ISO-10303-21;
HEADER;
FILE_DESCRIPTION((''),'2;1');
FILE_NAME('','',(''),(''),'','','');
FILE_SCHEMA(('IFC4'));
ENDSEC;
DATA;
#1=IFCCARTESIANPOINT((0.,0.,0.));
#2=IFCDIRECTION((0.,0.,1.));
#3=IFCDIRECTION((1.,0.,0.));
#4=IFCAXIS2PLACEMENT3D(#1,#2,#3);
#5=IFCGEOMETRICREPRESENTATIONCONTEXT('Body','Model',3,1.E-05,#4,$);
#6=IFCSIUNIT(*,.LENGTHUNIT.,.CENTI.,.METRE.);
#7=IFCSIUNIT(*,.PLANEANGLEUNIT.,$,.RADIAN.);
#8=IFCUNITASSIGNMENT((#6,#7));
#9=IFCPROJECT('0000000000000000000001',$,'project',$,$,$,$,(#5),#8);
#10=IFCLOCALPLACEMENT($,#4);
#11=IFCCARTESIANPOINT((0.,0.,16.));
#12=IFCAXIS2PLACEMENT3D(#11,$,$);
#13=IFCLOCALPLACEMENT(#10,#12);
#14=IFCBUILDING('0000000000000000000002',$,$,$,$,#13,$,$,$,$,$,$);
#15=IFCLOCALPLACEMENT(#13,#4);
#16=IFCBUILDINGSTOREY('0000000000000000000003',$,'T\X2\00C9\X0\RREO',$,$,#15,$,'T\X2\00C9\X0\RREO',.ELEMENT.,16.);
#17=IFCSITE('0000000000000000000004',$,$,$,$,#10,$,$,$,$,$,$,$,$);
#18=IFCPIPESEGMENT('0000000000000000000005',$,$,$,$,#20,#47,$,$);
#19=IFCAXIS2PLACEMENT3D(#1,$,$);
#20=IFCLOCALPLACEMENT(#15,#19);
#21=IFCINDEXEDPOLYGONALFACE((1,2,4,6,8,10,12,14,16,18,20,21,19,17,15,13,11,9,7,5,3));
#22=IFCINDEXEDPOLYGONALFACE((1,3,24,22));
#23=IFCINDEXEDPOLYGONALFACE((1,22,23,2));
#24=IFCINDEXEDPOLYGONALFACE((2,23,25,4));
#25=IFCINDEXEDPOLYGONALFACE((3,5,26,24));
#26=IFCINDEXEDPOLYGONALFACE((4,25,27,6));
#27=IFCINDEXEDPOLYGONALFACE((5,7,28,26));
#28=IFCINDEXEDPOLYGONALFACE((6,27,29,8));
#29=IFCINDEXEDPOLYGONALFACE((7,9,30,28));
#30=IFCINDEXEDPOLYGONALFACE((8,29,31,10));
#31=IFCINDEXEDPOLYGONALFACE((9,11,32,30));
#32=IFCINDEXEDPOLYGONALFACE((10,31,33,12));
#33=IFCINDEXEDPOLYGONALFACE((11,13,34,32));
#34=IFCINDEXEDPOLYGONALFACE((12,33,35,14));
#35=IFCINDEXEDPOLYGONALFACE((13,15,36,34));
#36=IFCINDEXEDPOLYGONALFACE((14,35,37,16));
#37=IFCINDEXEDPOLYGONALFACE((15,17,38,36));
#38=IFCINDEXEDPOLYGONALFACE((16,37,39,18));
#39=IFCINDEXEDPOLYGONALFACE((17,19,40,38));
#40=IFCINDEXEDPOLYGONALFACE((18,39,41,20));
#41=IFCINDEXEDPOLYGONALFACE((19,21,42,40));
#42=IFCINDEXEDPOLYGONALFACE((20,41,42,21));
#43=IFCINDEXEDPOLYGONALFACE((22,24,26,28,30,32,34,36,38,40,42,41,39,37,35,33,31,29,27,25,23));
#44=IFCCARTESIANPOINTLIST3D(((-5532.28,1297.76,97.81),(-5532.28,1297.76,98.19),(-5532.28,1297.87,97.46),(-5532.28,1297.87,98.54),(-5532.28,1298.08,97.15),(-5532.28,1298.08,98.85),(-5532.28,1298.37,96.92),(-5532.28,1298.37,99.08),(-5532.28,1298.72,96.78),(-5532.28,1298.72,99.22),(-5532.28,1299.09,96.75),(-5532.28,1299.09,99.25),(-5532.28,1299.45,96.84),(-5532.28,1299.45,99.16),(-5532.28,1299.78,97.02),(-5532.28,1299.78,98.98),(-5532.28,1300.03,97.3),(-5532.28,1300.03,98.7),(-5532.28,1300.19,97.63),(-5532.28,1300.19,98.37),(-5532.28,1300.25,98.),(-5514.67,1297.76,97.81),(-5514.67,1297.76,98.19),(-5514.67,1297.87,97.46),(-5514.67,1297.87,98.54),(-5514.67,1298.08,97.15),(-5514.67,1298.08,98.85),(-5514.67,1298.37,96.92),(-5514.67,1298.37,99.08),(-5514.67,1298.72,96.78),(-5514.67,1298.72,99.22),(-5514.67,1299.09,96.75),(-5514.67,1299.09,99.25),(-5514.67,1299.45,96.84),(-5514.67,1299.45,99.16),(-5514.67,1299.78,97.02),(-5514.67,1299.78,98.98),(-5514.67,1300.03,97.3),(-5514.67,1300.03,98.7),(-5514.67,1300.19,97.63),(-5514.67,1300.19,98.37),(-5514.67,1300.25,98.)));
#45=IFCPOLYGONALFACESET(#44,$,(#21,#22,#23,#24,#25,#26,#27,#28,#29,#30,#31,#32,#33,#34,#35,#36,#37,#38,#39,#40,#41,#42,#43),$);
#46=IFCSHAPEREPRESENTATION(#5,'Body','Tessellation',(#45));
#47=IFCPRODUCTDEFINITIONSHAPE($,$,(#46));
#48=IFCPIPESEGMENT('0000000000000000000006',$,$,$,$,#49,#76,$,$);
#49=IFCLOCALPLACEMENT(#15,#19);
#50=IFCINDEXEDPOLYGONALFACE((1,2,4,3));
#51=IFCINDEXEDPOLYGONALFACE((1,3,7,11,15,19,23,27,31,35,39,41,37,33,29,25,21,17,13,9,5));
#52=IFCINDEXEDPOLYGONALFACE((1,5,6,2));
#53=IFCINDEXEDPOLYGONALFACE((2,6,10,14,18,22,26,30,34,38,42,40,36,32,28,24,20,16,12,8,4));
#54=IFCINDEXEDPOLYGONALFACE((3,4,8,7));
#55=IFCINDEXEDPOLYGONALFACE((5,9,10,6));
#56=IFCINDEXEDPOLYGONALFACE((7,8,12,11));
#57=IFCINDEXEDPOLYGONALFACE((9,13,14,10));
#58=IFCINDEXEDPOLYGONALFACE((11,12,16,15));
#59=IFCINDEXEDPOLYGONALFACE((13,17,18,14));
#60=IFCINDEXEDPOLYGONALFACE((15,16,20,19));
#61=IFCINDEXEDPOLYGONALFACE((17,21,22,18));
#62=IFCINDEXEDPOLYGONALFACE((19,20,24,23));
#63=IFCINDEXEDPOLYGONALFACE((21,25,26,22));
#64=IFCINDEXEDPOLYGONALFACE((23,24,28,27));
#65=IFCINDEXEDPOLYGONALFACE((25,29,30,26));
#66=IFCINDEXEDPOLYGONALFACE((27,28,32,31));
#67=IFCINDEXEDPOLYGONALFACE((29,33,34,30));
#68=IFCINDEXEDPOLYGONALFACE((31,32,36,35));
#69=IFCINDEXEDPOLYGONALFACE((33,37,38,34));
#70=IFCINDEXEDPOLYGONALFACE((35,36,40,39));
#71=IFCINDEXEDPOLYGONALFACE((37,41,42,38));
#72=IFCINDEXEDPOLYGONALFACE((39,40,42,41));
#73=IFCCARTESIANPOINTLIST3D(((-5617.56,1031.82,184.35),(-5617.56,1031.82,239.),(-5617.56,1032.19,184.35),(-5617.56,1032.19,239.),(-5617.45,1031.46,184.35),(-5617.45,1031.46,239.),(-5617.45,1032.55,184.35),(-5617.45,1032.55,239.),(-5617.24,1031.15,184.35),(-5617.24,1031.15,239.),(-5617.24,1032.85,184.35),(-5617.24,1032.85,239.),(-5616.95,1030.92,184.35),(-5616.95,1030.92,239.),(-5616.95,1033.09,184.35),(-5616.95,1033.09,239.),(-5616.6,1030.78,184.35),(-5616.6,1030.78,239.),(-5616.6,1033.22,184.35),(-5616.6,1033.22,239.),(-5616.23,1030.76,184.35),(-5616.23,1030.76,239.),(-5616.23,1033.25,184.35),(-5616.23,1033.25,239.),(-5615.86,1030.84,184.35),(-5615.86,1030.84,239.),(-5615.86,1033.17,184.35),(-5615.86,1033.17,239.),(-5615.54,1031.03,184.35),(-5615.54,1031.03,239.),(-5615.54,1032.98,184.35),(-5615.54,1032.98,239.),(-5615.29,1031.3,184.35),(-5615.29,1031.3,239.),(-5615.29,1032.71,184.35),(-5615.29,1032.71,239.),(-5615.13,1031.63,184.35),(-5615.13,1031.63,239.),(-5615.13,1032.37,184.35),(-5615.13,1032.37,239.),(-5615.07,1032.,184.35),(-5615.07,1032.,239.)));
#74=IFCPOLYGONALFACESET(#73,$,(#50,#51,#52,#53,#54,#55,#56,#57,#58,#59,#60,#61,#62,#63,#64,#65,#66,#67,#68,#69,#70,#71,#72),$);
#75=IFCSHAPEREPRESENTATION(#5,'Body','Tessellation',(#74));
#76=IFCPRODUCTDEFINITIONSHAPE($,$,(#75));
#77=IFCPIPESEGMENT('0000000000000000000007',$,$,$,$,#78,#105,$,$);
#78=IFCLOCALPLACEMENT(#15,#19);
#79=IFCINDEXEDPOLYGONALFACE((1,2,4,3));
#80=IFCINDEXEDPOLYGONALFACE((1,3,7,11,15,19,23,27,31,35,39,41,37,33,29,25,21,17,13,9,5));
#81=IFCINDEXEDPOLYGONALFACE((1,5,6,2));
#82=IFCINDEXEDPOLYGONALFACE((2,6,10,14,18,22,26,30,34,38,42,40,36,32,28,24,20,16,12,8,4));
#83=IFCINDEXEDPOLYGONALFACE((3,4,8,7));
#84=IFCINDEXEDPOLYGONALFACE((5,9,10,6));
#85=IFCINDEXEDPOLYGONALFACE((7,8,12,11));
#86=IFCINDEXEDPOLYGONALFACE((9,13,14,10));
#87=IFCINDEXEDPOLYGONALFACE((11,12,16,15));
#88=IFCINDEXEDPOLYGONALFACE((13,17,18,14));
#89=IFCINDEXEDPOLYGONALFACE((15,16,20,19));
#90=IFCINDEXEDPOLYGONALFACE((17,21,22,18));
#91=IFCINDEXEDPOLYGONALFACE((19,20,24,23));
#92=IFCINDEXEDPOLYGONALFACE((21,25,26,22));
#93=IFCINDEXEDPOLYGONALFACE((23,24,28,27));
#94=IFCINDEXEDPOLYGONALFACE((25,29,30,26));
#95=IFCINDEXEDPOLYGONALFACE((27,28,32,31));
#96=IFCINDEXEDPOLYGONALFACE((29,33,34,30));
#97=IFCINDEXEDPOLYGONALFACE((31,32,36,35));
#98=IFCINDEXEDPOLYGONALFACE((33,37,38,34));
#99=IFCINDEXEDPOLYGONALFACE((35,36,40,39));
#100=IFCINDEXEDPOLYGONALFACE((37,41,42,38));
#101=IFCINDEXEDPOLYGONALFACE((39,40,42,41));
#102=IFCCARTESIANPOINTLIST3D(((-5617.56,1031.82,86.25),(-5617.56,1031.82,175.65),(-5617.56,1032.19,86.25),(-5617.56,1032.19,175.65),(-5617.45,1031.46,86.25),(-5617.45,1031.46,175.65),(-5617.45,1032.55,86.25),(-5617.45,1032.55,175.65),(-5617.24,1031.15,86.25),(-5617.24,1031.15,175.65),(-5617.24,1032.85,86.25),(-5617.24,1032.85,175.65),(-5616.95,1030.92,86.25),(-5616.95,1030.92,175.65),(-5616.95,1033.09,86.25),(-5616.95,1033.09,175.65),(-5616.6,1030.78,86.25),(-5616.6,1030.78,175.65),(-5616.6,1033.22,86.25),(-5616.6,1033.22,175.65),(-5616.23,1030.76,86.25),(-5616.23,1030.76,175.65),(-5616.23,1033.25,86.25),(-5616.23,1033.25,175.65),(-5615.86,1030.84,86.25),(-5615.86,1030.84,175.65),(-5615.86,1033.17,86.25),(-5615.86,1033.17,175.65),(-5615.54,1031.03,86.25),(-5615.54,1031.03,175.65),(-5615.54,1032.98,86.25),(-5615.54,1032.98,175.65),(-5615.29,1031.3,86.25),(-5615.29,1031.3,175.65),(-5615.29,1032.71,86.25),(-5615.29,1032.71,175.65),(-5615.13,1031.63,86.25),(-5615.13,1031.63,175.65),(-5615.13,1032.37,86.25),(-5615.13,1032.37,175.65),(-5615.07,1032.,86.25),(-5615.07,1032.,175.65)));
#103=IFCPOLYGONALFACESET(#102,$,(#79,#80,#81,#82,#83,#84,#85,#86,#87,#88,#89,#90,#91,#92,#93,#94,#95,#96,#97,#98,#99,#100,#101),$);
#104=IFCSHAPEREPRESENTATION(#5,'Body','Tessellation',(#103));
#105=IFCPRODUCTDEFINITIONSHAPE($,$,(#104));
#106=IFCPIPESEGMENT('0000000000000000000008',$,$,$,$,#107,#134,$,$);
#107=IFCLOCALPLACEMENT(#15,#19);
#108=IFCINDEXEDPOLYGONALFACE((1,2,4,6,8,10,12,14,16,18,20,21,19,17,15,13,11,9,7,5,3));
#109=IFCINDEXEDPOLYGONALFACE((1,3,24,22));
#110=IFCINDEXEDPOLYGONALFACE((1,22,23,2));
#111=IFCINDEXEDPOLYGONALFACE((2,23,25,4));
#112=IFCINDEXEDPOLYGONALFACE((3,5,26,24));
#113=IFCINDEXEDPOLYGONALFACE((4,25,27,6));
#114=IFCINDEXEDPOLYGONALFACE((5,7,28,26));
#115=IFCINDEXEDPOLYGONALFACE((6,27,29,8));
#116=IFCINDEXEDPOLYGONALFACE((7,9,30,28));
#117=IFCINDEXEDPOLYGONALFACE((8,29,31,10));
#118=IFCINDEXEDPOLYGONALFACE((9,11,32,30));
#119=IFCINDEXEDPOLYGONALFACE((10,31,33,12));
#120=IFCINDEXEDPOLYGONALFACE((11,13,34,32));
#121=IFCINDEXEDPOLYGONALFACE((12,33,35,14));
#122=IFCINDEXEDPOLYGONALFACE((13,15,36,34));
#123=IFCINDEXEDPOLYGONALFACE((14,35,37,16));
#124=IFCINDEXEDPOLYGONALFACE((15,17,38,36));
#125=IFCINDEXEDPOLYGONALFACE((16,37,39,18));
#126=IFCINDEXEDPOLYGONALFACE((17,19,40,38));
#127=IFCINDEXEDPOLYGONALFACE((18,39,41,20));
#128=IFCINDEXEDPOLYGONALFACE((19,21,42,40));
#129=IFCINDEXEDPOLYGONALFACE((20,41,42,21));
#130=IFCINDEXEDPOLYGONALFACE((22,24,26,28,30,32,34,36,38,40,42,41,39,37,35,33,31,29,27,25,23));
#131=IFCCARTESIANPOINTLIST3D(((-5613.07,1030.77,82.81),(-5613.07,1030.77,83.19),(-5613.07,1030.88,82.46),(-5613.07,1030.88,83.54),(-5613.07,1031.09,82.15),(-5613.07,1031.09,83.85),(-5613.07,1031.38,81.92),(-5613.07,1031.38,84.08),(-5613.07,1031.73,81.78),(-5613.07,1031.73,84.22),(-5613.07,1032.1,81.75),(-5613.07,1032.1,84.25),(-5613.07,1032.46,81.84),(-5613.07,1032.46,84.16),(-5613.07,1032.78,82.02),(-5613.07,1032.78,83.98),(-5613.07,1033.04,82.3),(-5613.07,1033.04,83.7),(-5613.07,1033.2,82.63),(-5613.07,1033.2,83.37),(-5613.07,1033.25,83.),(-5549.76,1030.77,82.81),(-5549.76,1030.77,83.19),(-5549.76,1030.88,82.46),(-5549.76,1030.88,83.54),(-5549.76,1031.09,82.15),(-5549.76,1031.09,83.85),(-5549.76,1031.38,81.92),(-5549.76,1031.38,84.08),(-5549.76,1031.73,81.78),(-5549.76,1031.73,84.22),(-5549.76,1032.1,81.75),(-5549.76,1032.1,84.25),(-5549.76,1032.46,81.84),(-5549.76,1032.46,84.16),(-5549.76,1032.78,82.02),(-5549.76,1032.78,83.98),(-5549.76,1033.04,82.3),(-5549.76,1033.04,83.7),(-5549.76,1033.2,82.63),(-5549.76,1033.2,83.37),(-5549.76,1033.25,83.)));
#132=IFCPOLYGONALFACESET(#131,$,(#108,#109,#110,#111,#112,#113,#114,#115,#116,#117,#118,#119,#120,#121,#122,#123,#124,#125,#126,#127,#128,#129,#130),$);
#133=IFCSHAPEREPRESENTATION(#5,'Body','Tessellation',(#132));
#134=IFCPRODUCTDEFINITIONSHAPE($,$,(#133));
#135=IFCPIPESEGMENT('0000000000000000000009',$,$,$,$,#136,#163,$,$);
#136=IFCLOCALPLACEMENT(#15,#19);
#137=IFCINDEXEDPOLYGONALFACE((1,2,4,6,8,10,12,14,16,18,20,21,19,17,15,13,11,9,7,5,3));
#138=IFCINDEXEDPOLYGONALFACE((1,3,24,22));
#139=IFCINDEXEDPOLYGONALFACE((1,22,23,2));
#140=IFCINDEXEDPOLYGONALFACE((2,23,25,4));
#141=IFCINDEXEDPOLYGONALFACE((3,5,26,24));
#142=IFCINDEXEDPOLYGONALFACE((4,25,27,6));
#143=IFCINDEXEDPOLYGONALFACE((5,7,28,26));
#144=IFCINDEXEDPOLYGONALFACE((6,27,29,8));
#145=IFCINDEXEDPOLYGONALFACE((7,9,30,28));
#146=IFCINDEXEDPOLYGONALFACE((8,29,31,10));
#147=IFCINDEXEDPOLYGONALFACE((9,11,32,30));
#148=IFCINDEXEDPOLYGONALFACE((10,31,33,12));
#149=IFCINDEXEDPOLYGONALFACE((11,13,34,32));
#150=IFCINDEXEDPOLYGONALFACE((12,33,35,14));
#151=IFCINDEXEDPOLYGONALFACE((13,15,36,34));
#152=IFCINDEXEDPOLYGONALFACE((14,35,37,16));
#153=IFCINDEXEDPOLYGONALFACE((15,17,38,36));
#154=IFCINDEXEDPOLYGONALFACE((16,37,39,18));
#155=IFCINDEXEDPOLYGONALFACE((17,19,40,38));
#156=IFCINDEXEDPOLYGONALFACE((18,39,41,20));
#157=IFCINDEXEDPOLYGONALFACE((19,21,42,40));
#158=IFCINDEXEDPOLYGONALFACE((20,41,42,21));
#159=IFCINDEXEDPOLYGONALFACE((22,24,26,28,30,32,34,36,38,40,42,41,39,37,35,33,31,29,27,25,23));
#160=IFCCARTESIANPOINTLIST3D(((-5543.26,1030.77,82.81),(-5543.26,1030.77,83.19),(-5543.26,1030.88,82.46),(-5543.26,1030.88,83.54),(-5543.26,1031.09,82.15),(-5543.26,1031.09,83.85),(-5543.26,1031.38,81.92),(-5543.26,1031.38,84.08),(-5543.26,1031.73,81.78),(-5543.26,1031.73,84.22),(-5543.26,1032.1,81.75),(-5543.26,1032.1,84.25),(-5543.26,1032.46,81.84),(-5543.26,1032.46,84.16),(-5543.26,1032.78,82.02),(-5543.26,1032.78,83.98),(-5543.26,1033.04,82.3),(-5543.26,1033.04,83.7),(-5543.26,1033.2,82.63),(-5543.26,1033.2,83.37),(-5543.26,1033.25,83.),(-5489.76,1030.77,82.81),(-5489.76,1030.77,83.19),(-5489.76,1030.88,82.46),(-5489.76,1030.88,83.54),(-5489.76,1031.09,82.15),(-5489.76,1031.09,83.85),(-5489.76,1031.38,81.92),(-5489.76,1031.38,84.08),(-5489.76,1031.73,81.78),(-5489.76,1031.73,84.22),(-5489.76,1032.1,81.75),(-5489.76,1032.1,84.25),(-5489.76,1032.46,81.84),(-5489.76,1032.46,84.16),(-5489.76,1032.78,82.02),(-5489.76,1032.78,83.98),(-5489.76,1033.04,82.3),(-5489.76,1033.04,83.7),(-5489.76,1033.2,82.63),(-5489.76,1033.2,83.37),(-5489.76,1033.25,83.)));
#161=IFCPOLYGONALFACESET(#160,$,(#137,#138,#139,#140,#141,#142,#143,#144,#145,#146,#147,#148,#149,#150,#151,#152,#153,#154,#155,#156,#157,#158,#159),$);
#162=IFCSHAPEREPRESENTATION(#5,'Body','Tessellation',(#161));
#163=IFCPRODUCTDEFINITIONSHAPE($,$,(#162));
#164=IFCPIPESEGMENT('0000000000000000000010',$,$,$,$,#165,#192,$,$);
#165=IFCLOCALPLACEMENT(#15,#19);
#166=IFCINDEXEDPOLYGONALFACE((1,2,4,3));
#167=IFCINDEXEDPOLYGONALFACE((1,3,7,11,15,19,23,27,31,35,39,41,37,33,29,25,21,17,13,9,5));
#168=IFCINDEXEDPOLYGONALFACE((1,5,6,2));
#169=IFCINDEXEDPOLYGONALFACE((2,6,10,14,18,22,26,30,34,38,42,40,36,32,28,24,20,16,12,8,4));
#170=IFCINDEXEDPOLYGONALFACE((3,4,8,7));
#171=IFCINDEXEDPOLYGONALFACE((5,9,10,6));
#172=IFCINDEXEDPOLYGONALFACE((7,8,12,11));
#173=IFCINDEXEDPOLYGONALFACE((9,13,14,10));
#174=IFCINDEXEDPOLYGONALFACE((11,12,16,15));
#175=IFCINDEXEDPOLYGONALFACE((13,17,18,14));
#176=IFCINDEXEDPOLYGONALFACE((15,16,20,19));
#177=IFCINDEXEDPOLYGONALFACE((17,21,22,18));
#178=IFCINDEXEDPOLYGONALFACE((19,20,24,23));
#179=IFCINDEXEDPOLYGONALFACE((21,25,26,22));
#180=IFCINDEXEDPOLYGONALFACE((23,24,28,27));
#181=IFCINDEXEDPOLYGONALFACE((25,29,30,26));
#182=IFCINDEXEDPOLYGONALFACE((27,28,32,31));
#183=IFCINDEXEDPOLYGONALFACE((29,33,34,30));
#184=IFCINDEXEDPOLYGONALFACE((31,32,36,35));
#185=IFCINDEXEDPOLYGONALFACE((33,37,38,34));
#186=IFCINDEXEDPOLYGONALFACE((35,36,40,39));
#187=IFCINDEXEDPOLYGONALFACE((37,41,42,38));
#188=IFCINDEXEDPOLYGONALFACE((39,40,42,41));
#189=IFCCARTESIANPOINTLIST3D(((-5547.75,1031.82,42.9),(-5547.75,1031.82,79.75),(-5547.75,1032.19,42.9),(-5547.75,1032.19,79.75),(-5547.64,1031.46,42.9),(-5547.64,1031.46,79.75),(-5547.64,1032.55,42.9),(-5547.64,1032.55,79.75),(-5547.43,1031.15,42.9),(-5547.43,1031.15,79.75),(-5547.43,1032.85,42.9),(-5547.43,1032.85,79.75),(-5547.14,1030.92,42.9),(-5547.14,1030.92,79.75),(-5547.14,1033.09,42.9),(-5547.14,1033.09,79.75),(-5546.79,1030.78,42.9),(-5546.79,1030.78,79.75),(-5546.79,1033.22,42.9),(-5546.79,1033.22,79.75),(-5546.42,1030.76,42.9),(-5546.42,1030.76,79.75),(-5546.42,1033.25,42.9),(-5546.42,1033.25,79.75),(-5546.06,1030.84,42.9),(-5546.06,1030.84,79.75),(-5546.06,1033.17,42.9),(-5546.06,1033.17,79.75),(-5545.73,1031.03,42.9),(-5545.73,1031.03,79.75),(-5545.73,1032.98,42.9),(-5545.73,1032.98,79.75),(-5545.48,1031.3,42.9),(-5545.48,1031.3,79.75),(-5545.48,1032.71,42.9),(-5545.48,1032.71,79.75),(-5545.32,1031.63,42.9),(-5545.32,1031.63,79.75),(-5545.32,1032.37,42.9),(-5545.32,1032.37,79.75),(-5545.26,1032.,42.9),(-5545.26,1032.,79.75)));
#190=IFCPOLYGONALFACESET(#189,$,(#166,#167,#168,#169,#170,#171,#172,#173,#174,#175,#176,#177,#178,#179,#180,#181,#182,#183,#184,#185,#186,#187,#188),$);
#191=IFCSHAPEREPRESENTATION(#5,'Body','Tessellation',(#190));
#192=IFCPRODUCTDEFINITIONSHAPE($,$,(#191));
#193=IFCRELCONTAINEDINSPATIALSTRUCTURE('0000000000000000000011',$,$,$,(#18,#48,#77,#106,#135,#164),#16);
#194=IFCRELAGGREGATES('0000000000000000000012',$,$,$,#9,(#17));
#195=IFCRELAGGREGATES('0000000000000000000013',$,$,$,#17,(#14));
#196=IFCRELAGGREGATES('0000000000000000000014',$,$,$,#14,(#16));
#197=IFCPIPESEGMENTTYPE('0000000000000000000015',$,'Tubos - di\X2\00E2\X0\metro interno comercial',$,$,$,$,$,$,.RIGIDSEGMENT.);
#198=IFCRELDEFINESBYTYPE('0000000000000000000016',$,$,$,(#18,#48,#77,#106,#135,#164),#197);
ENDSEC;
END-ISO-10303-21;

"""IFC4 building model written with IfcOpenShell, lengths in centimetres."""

from ifc_helpers import new_model, si_unit, frame, origin_with_axes, origin_2d_with_axis, place, context, project, spatial, circle, extrude, type_object, element, save


model = new_model("IFC4")

# Units and contexts
model_context = context("Model", 3, precision=1e-05, world=origin_with_axes(), identifier="Body")
ifc_project = project(units=[si_unit("LENGTHUNIT", "METRE", prefix="CENTI"), si_unit("PLANEANGLEUNIT", "RADIAN")], contexts=[model_context])

# Site, building, storey
site_placement = place(None, origin_with_axes())
site = spatial("IfcSite", under=ifc_project, at=site_placement)
building_placement = place(site_placement, frame((0.0, 0.0, 16.0)))
building = spatial("IfcBuilding", under=site, at=building_placement)
storey_placement = place(building_placement, origin_with_axes())
storey = spatial("IfcBuildingStorey", under=building, at=storey_placement, Name="TÉRREO", LongName="TÉRREO", CompositionType="ELEMENT", Elevation=16.0)

# Pipe segments
pipe_segment_type = type_object("IfcPipeSegmentType", Name="Tubos - diâmetro interno comercial", PredefinedType="RIGIDSEGMENT")
pipe_segment_1_placement = place(storey_placement, frame((-5523.47, 1299.0, 99.25), z_axis=(0.0, 0.0, 1.0), x_axis=(1.0, 0.0, 0.0)))
element("IfcPipeSegment", 1, at=pipe_segment_1_placement, inside=storey, type_object=pipe_segment_type, context=model_context, shape_type="SolidModel", body=[
    extrude(circle(Radius=1.25, at=origin_2d_with_axis()), frame((8.8, 0.0, -1.25), z_axis=(-1.0, 0.0, 0.0), x_axis=(0.0, 1.0, 0.0)), (0.0, 0.0, 1.0), 17.61),
])
pipe_segment_2_placement = place(storey_placement, frame((-5616.32, 1032.0, 239.0), z_axis=(0.0, 0.0, 1.0), x_axis=(1.0, 0.0, 0.0)))
element("IfcPipeSegment", 2, at=pipe_segment_2_placement, inside=storey, type_object=pipe_segment_type, context=model_context, shape_type="SolidModel", body=[
    extrude(circle(Radius=1.25, at=origin_2d_with_axis()), frame((0.0, 0.0, 0.0), z_axis=(0.0, 0.0, -1.0), x_axis=(1.0, 0.0, 0.0)), (0.0, 0.0, 1.0), 54.65),
])
pipe_segment_3_placement = place(storey_placement, frame((-5616.32, 1032.0, 175.65), z_axis=(0.0, 0.0, 1.0), x_axis=(1.0, 0.0, 0.0)))
element("IfcPipeSegment", 3, at=pipe_segment_3_placement, inside=storey, type_object=pipe_segment_type, context=model_context, shape_type="SolidModel", body=[
    extrude(circle(Radius=1.25, at=origin_2d_with_axis()), frame((0.0, 0.0, 0.0), z_axis=(0.0, 0.0, -1.0), x_axis=(1.0, 0.0, 0.0)), (0.0, 0.0, 1.0), 89.4),
])
pipe_segment_4_placement = place(storey_placement, frame((-5581.42, 1032.0, 84.25), z_axis=(0.0, 0.0, 1.0), x_axis=(1.0, 0.0, 0.0)))
element("IfcPipeSegment", 4, at=pipe_segment_4_placement, inside=storey, type_object=pipe_segment_type, context=model_context, shape_type="SolidModel", body=[
    extrude(circle(Radius=1.25, at=origin_2d_with_axis()), frame((-31.65, 0.0, -1.25), z_axis=(1.0, 0.0, 0.0), x_axis=(0.0, 1.0, 0.0)), (0.0, 0.0, 1.0), 63.31),
])
pipe_segment_5_placement = place(storey_placement, frame((-5516.51, 1032.0, 84.25), z_axis=(0.0, 0.0, 1.0), x_axis=(1.0, 0.0, 0.0)))
element("IfcPipeSegment", 5, at=pipe_segment_5_placement, inside=storey, type_object=pipe_segment_type, context=model_context, shape_type="SolidModel", body=[
    extrude(circle(Radius=1.25, at=origin_2d_with_axis()), frame((-26.75, 0.0, -1.25), z_axis=(1.0, 0.0, 0.0), x_axis=(0.0, 1.0, 0.0)), (0.0, 0.0, 1.0), 53.5),
])
pipe_segment_6_placement = place(storey_placement, frame((-5546.51, 1032.0, 79.75), z_axis=(0.0, 0.0, 1.0), x_axis=(1.0, 0.0, 0.0)))
element("IfcPipeSegment", 6, at=pipe_segment_6_placement, inside=storey, type_object=pipe_segment_type, context=model_context, shape_type="SolidModel", body=[
    extrude(circle(Radius=1.25, at=origin_2d_with_axis()), frame((0.0, 0.0, 0.0), z_axis=(0.0, 0.0, -1.0), x_axis=(1.0, 0.0, 0.0)), (0.0, 0.0, 1.0), 36.85),
])

save(model, "model.ifc")
